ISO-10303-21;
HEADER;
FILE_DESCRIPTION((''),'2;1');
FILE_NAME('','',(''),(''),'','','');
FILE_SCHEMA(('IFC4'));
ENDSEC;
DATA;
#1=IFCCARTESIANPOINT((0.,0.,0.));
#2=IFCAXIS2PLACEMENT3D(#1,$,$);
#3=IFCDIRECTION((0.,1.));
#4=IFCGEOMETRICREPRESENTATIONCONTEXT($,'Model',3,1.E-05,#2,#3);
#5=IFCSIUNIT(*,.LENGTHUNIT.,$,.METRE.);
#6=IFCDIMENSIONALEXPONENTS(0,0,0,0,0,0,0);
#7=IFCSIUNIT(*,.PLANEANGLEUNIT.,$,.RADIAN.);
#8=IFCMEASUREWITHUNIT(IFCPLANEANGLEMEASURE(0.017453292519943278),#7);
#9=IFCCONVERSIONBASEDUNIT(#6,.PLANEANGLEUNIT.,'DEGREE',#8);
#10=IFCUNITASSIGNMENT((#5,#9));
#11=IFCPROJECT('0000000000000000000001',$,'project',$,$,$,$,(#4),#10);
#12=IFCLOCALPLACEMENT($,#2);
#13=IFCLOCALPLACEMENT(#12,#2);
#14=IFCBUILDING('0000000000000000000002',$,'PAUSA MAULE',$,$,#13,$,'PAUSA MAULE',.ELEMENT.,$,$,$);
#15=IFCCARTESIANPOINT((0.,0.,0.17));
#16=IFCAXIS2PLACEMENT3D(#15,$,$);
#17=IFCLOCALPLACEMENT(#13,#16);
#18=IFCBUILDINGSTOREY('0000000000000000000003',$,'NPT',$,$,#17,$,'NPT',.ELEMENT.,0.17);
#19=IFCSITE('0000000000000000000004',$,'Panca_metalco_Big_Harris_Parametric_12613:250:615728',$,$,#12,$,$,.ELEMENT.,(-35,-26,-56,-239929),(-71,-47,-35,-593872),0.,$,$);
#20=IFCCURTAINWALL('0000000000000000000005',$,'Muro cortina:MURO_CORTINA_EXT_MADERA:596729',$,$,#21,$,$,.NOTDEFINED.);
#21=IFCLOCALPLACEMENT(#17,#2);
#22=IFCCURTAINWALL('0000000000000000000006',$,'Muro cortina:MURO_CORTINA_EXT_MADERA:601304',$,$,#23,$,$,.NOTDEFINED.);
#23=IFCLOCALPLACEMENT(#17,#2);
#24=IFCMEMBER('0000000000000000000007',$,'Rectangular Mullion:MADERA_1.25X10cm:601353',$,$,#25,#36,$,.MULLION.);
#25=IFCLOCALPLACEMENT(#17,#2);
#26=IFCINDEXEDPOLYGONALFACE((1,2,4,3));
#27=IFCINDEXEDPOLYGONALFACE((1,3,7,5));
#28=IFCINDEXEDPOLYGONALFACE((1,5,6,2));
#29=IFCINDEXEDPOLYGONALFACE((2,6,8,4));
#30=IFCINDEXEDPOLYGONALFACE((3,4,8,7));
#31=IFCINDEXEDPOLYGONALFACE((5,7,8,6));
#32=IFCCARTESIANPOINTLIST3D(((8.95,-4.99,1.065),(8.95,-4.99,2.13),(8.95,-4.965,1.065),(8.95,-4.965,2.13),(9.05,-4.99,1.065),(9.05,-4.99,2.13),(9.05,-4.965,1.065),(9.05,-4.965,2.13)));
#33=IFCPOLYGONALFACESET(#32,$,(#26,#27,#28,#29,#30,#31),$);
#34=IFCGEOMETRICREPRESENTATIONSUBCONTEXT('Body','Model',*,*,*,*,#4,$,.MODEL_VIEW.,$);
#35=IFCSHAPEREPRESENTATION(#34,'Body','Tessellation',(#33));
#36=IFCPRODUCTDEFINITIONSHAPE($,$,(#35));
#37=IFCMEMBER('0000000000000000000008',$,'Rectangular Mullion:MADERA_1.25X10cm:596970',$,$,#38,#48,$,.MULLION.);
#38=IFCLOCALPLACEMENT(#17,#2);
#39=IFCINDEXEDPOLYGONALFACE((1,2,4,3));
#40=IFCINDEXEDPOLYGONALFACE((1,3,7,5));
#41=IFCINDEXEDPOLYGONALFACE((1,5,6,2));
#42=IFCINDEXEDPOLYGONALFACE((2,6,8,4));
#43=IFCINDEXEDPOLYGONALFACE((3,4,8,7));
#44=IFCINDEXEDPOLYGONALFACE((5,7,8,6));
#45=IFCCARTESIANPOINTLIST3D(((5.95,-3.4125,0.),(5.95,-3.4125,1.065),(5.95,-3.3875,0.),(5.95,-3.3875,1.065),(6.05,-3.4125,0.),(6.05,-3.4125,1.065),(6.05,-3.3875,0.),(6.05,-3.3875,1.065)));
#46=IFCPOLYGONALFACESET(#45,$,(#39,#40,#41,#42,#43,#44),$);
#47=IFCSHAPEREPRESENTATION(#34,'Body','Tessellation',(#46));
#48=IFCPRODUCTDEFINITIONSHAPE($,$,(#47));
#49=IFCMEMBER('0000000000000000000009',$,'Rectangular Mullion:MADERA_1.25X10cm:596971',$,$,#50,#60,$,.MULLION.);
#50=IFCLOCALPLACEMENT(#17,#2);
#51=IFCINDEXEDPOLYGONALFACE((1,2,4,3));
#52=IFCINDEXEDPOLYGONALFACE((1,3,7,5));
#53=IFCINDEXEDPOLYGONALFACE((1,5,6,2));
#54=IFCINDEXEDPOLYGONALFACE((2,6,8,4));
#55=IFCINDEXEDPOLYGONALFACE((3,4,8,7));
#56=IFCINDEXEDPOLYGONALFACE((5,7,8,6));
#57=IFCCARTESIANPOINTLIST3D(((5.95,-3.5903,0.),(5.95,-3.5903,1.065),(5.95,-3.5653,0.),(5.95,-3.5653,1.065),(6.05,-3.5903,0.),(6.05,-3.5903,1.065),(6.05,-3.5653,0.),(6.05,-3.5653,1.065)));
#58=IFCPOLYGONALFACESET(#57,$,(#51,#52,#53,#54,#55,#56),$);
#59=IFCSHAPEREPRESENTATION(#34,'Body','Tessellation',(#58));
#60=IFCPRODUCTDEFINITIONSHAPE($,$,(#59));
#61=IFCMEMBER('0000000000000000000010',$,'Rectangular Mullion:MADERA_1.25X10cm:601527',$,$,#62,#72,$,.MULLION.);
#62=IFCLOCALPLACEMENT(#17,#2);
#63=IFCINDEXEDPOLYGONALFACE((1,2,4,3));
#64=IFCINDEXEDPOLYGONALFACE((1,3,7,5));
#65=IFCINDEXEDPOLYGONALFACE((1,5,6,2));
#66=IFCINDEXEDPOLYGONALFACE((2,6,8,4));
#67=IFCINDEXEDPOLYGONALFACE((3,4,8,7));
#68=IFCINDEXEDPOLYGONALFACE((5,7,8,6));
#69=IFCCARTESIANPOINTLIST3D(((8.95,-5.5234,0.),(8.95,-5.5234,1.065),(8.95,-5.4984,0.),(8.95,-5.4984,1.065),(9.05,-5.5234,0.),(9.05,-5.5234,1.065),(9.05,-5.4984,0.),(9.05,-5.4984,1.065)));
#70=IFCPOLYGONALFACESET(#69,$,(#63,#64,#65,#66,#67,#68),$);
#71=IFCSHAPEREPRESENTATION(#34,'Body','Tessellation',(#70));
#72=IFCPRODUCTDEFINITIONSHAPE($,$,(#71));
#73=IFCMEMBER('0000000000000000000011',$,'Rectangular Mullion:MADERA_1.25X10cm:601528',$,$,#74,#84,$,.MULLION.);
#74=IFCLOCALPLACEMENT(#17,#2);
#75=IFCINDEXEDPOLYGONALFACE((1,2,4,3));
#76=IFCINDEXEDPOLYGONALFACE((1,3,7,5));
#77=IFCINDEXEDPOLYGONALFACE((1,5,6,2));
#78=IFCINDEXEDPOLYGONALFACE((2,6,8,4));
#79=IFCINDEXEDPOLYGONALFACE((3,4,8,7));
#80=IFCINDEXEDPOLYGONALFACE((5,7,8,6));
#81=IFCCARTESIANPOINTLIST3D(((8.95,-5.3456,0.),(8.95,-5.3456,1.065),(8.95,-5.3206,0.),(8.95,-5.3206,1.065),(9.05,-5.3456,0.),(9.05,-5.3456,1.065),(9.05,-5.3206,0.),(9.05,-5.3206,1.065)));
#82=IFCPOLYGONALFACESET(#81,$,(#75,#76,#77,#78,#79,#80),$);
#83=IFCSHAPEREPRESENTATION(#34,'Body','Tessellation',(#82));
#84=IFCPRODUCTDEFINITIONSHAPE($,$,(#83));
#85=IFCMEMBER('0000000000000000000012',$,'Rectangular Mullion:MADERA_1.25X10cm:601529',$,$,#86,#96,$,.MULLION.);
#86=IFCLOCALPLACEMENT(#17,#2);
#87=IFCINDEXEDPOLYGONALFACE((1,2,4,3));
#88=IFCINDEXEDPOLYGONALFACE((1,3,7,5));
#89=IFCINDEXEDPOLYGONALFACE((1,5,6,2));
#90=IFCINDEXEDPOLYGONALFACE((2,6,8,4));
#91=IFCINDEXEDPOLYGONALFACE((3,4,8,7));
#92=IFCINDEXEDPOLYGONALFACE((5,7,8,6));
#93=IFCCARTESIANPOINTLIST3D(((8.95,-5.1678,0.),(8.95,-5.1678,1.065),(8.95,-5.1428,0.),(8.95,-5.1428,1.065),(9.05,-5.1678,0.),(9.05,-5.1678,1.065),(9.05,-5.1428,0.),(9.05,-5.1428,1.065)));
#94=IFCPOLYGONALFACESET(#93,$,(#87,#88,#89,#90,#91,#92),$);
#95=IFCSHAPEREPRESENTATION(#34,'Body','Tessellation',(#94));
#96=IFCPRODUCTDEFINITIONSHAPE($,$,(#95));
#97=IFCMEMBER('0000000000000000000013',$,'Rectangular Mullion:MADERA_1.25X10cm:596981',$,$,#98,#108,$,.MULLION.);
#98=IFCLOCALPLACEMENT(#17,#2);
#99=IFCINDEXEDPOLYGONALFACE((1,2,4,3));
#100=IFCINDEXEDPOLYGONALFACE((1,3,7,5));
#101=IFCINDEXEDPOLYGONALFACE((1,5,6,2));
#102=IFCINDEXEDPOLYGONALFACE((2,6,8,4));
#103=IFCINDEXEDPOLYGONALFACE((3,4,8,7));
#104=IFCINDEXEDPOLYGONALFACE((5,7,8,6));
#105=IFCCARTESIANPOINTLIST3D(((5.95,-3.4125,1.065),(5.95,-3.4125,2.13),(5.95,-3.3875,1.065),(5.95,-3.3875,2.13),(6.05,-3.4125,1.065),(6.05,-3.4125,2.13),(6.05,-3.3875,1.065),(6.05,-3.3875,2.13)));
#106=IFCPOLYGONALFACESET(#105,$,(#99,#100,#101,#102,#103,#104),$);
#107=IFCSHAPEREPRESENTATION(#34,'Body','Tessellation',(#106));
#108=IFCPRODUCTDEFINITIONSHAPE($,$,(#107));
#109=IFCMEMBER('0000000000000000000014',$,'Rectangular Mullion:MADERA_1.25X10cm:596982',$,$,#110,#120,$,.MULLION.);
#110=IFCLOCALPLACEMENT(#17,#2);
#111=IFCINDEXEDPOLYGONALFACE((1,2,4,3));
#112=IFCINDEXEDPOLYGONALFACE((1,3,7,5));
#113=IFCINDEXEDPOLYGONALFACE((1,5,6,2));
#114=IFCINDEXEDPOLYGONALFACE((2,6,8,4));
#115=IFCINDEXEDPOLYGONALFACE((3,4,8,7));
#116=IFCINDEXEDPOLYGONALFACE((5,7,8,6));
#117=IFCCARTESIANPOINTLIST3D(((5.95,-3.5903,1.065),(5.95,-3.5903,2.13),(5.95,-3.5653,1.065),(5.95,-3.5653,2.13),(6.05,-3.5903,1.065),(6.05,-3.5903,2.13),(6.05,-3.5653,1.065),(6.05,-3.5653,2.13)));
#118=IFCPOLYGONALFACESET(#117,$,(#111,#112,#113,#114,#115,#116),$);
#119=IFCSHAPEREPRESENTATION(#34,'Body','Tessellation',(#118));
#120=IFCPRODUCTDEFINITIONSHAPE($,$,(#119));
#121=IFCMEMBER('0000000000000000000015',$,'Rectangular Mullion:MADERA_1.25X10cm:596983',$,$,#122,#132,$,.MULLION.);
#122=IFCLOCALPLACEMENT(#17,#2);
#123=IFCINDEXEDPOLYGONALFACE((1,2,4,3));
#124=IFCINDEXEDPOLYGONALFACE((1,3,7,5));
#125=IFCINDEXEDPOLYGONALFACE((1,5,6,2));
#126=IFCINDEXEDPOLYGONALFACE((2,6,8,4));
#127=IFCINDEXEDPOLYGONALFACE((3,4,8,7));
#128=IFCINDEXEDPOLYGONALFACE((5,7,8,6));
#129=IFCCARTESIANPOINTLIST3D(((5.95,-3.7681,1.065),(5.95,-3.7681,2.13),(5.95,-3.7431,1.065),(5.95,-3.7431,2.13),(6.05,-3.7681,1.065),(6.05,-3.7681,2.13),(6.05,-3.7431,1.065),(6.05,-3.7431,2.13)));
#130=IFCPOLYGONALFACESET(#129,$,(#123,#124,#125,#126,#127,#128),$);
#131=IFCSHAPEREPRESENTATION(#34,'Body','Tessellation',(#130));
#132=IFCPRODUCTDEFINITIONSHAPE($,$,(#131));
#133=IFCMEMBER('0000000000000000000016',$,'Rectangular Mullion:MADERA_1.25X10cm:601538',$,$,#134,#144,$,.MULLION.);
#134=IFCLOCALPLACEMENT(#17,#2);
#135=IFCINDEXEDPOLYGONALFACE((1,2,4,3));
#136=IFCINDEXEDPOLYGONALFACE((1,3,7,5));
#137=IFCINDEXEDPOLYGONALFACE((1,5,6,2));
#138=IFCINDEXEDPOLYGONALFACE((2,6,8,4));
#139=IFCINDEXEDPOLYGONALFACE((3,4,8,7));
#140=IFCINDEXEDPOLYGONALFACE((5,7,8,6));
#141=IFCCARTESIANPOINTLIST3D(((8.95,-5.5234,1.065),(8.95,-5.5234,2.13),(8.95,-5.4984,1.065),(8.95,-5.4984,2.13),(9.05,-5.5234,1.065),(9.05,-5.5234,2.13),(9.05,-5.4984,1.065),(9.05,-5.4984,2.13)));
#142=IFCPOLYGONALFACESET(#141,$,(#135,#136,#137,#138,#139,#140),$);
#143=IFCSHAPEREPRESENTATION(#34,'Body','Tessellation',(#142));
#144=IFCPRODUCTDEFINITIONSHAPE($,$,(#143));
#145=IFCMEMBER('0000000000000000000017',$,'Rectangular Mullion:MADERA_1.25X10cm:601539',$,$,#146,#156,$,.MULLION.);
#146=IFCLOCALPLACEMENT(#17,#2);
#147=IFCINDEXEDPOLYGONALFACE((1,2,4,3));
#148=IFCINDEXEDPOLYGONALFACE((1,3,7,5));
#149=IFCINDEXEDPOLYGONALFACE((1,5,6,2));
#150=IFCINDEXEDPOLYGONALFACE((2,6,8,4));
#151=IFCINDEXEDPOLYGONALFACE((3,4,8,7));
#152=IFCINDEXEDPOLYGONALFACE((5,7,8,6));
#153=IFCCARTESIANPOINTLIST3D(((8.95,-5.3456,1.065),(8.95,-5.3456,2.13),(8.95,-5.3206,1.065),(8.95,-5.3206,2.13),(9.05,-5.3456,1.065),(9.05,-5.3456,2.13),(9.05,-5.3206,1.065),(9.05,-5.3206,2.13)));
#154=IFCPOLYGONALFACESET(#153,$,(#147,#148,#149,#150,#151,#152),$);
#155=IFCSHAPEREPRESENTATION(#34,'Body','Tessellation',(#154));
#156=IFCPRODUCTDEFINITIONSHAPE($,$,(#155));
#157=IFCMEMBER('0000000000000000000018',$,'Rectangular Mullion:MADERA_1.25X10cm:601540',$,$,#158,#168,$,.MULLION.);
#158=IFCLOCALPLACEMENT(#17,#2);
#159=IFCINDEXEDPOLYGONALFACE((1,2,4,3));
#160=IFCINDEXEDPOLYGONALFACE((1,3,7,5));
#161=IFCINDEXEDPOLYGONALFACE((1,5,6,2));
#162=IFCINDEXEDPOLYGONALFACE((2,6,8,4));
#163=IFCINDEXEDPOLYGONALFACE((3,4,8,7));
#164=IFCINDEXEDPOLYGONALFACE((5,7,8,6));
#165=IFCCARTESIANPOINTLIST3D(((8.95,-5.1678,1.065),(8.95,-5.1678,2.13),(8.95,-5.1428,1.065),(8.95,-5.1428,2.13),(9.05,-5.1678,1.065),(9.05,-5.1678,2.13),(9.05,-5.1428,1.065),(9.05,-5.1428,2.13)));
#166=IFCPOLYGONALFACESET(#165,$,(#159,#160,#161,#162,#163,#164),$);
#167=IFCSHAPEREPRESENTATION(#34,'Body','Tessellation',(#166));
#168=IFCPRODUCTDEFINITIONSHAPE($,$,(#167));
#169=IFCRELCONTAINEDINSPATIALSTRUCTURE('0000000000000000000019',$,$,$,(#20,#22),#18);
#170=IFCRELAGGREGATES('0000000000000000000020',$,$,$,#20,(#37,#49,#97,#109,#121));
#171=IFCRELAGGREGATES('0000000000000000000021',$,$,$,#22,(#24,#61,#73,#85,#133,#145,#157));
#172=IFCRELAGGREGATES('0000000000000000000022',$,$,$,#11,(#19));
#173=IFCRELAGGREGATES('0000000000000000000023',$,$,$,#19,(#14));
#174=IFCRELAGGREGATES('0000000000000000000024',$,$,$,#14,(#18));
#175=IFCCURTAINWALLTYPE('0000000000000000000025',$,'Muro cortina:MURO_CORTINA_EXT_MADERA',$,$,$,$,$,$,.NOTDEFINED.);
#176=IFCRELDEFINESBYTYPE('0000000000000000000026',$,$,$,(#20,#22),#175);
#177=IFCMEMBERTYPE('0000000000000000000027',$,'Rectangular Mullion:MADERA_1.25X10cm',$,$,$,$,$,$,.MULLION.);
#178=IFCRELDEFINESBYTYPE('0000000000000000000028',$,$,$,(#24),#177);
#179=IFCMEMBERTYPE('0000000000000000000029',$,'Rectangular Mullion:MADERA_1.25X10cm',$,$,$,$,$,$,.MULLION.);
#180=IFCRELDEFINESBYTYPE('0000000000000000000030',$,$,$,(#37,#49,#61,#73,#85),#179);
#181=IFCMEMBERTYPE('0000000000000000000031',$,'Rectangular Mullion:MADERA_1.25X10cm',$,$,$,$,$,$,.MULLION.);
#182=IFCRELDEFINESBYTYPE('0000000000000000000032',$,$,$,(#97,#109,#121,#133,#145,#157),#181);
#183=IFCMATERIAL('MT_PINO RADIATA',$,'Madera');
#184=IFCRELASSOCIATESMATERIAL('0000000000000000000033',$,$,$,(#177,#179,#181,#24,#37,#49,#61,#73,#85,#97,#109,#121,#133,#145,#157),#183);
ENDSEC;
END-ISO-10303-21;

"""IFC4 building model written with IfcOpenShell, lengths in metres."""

from ifc_helpers import new_model, entity, si_unit, converted_unit, direction, frame, frame_2d, origin, origin_2d_with_axis, place, context, subcontext, project, spatial, rectangle, extrude, source, transform, mapped, material, material_profile, profile_set, profile_usage, type_object, type_shapes, element, aggregate, save


model = new_model("IFC4")

# Units and contexts
model_context = context("Model", 3, precision=1e-05, world=origin(), true_north=direction((0.0, 1.0)))
body_context = subcontext(model_context, "Body", "Model", "MODEL_VIEW")
ifc_project = project(units=[si_unit("LENGTHUNIT", "METRE"), converted_unit("PLANEANGLEUNIT", "DEGREE", entity("IfcPlaneAngleMeasure", 0.017453292519943278), si_unit("PLANEANGLEUNIT", "RADIAN"), dimensions=[0, 0, 0, 0, 0, 0, 0])], contexts=[model_context])

# Site, building, storey
site_placement = place(None, origin())
site = spatial("IfcSite", under=ifc_project, at=site_placement, Name="Panca_metalco_Big_Harris_Parametric_12613:250:615728", CompositionType="ELEMENT", RefLatitude=(-35, -26, -56, -239929), RefLongitude=(-71, -47, -35, -593872), RefElevation=0.0)
building_placement = place(site_placement, origin())
building = spatial("IfcBuilding", under=site, at=building_placement, Name="PAUSA MAULE", LongName="PAUSA MAULE", CompositionType="ELEMENT")
storey_placement = place(building_placement, frame((0.0, 0.0, 0.17)))
storey = spatial("IfcBuildingStorey", under=building, at=storey_placement, Name="NPT", LongName="NPT", CompositionType="ELEMENT", Elevation=0.17)

# Curtain walls
curtain_wall_type = type_object("IfcCurtainWallType", Name="Muro cortina:MURO_CORTINA_EXT_MADERA", PredefinedType="NOTDEFINED")
curtain_wall_1_placement = place(storey_placement, frame((0.0, 0.0, -0.17)))
curtain_wall_1 = element("IfcCurtainWall", 1, at=curtain_wall_1_placement, inside=storey, type_object=curtain_wall_type, Name="Muro cortina:MURO_CORTINA_EXT_MADERA:596729", PredefinedType="NOTDEFINED")
ifc_material = material(Name="MT_PINO RADIATA", Category="Madera")
ifc_material_profile = material_profile(ifc_material, rectangle(XDim=0.025, YDim=0.1, at=frame_2d((0.0, 0.0), x_axis=(1.0, 0.0))), Name="MADERA_1.25X10cm")
ifc_profile_set = profile_set([ifc_material_profile], Name="MADERA_1.25X10cm")
ifc_profile_usage = profile_usage(ifc_profile_set)
curtain_wall_2_placement = place(storey_placement, frame((0.0, 0.0, -0.17)))
curtain_wall_2 = element("IfcCurtainWall", 2, at=curtain_wall_2_placement, inside=storey, type_object=curtain_wall_type, Name="Muro cortina:MURO_CORTINA_EXT_MADERA:601304", PredefinedType="NOTDEFINED")

# Members
member_type_1 = type_object("IfcMemberType", Name="Rectangular Mullion:MADERA_1.25X10cm", PredefinedType="MULLION", material=ifc_profile_set)
shared_shape_1 = source(origin(), body_context, "Body", "SweptSolid", [
    extrude(rectangle(XDim=0.025, YDim=0.1, at=origin_2d_with_axis()), frame((-0.0125, 0.0, -1.065), z_axis=(0.0, 0.0, 1.0), x_axis=(-1.0, 0.0, 0.0)), (0.0, 0.0, 1.0), 1.065),
])
type_shapes(member_type_1, [shared_shape_1])
member_1_placement = place(curtain_wall_2_placement, frame((9.0, -4.965, 1.235), z_axis=(0.0, 0.0, -1.0), x_axis=(0.0, 1.0, 0.0)))
member_1 = element("IfcMember", 3, at=member_1_placement, type_object=member_type_1, material=ifc_profile_usage, Name="Rectangular Mullion:MADERA_1.25X10cm:601353", PredefinedType="MULLION", context=body_context, shape_type="MappedRepresentation", body=[
    mapped(shared_shape_1, transform((0.0, 0.0, 0.0), scale=1.0)),
])
member_type_2 = type_object("IfcMemberType", Name="Rectangular Mullion:MADERA_1.25X10cm", PredefinedType="MULLION", material=ifc_profile_set)
shared_shape_2 = source(origin(), body_context, "Body", "SweptSolid", [
    extrude(rectangle(XDim=0.025, YDim=0.1, at=frame_2d((0.0, 0.0), x_axis=(1.0, 0.0))), frame((0.0, 0.0, -1.065), z_axis=(0.0, 0.0, 1.0), x_axis=(-1.0, 0.0, 0.0)), (0.0, 0.0, 1.0), 1.065),
])
type_shapes(member_type_2, [shared_shape_2])
member_2_placement = place(curtain_wall_1_placement, frame((6.0, -3.4, 0.17), z_axis=(0.0, 0.0, -1.0), x_axis=(0.0, -1.0, 0.0)))
member_2 = element("IfcMember", 4, at=member_2_placement, type_object=member_type_2, material=ifc_profile_usage, Name="Rectangular Mullion:MADERA_1.25X10cm:596970", PredefinedType="MULLION", context=body_context, shape_type="MappedRepresentation", body=[
    mapped(shared_shape_2, transform((0.0, 0.0, 0.0), scale=1.0)),
])
member_3_placement = place(curtain_wall_1_placement, frame((6.0, -3.5778, 0.17), z_axis=(0.0, 0.0, -1.0), x_axis=(0.0, -1.0, 0.0)))
member_3 = element("IfcMember", 5, at=member_3_placement, type_object=member_type_2, material=ifc_profile_usage, Name="Rectangular Mullion:MADERA_1.25X10cm:596971", PredefinedType="MULLION", context=body_context, shape_type="MappedRepresentation", body=[
    mapped(shared_shape_2, transform((0.0, 0.0, 0.0), scale=1.0)),
])
member_4_placement = place(curtain_wall_2_placement, frame((9.0, -5.5109, 0.17), z_axis=(0.0, 0.0, -1.0), x_axis=(0.0, 1.0, 0.0)))
member_4 = element("IfcMember", 6, at=member_4_placement, type_object=member_type_2, material=ifc_profile_usage, Name="Rectangular Mullion:MADERA_1.25X10cm:601527", PredefinedType="MULLION", context=body_context, shape_type="MappedRepresentation", body=[
    mapped(shared_shape_2, transform((0.0, 0.0, 0.0), scale=1.0)),
])
member_5_placement = place(curtain_wall_2_placement, frame((9.0, -5.3331, 0.17), z_axis=(0.0, 0.0, -1.0), x_axis=(0.0, 1.0, 0.0)))
member_5 = element("IfcMember", 7, at=member_5_placement, type_object=member_type_2, material=ifc_profile_usage, Name="Rectangular Mullion:MADERA_1.25X10cm:601528", PredefinedType="MULLION", context=body_context, shape_type="MappedRepresentation", body=[
    mapped(shared_shape_2, transform((0.0, 0.0, 0.0), scale=1.0)),
])
member_6_placement = place(curtain_wall_2_placement, frame((9.0, -5.1553, 0.17), z_axis=(0.0, 0.0, -1.0), x_axis=(0.0, 1.0, 0.0)))
member_6 = element("IfcMember", 8, at=member_6_placement, type_object=member_type_2, material=ifc_profile_usage, Name="Rectangular Mullion:MADERA_1.25X10cm:601529", PredefinedType="MULLION", context=body_context, shape_type="MappedRepresentation", body=[
    mapped(shared_shape_2, transform((0.0, 0.0, 0.0), scale=1.0)),
])
member_type_3 = type_object("IfcMemberType", Name="Rectangular Mullion:MADERA_1.25X10cm", PredefinedType="MULLION", material=ifc_profile_set)
shared_shape_3 = source(origin(), body_context, "Body", "SweptSolid", [
    extrude(rectangle(XDim=0.025, YDim=0.1, at=frame_2d((0.0, 0.0), x_axis=(1.0, 0.0))), frame((0.0, 0.0, -1.065), z_axis=(0.0, 0.0, 1.0), x_axis=(-1.0, 0.0, 0.0)), (0.0, 0.0, 1.0), 1.065),
])
type_shapes(member_type_3, [shared_shape_3])
member_7_placement = place(curtain_wall_1_placement, frame((6.0, -3.4, 1.235), z_axis=(0.0, 0.0, -1.0), x_axis=(0.0, -1.0, 0.0)))
member_7 = element("IfcMember", 9, at=member_7_placement, type_object=member_type_3, material=ifc_profile_usage, Name="Rectangular Mullion:MADERA_1.25X10cm:596981", PredefinedType="MULLION", context=body_context, shape_type="MappedRepresentation", body=[
    mapped(shared_shape_3, transform((0.0, 0.0, 0.0), scale=1.0)),
])
member_8_placement = place(curtain_wall_1_placement, frame((6.0, -3.5778, 1.235), z_axis=(0.0, 0.0, -1.0), x_axis=(0.0, -1.0, 0.0)))
member_8 = element("IfcMember", 10, at=member_8_placement, type_object=member_type_3, material=ifc_profile_usage, Name="Rectangular Mullion:MADERA_1.25X10cm:596982", PredefinedType="MULLION", context=body_context, shape_type="MappedRepresentation", body=[
    mapped(shared_shape_3, transform((0.0, 0.0, 0.0), scale=1.0)),
])
member_9_placement = place(curtain_wall_1_placement, frame((6.0, -3.7556, 1.235), z_axis=(0.0, 0.0, -1.0), x_axis=(0.0, -1.0, 0.0)))
member_9 = element("IfcMember", 11, at=member_9_placement, type_object=member_type_3, material=ifc_profile_usage, Name="Rectangular Mullion:MADERA_1.25X10cm:596983", PredefinedType="MULLION", context=body_context, shape_type="MappedRepresentation", body=[
    mapped(shared_shape_3, transform((0.0, 0.0, 0.0), scale=1.0)),
])
aggregate(curtain_wall_1, [member_2, member_3, member_7, member_8, member_9])
member_10_placement = place(curtain_wall_2_placement, frame((9.0, -5.5109, 1.235), z_axis=(0.0, 0.0, -1.0), x_axis=(0.0, 1.0, 0.0)))
member_10 = element("IfcMember", 12, at=member_10_placement, type_object=member_type_3, material=ifc_profile_usage, Name="Rectangular Mullion:MADERA_1.25X10cm:601538", PredefinedType="MULLION", context=body_context, shape_type="MappedRepresentation", body=[
    mapped(shared_shape_3, transform((0.0, 0.0, 0.0), scale=1.0)),
])
member_11_placement = place(curtain_wall_2_placement, frame((9.0, -5.3331, 1.235), z_axis=(0.0, 0.0, -1.0), x_axis=(0.0, 1.0, 0.0)))
member_11 = element("IfcMember", 13, at=member_11_placement, type_object=member_type_3, material=ifc_profile_usage, Name="Rectangular Mullion:MADERA_1.25X10cm:601539", PredefinedType="MULLION", context=body_context, shape_type="MappedRepresentation", body=[
    mapped(shared_shape_3, transform((0.0, 0.0, 0.0), scale=1.0)),
])
member_12_placement = place(curtain_wall_2_placement, frame((9.0, -5.1553, 1.235), z_axis=(0.0, 0.0, -1.0), x_axis=(0.0, 1.0, 0.0)))
member_12 = element("IfcMember", 14, at=member_12_placement, type_object=member_type_3, material=ifc_profile_usage, Name="Rectangular Mullion:MADERA_1.25X10cm:601540", PredefinedType="MULLION", context=body_context, shape_type="MappedRepresentation", body=[
    mapped(shared_shape_3, transform((0.0, 0.0, 0.0), scale=1.0)),
])
aggregate(curtain_wall_2, [member_1, member_4, member_5, member_6, member_10, member_11, member_12])

save(model, "model.ifc")
